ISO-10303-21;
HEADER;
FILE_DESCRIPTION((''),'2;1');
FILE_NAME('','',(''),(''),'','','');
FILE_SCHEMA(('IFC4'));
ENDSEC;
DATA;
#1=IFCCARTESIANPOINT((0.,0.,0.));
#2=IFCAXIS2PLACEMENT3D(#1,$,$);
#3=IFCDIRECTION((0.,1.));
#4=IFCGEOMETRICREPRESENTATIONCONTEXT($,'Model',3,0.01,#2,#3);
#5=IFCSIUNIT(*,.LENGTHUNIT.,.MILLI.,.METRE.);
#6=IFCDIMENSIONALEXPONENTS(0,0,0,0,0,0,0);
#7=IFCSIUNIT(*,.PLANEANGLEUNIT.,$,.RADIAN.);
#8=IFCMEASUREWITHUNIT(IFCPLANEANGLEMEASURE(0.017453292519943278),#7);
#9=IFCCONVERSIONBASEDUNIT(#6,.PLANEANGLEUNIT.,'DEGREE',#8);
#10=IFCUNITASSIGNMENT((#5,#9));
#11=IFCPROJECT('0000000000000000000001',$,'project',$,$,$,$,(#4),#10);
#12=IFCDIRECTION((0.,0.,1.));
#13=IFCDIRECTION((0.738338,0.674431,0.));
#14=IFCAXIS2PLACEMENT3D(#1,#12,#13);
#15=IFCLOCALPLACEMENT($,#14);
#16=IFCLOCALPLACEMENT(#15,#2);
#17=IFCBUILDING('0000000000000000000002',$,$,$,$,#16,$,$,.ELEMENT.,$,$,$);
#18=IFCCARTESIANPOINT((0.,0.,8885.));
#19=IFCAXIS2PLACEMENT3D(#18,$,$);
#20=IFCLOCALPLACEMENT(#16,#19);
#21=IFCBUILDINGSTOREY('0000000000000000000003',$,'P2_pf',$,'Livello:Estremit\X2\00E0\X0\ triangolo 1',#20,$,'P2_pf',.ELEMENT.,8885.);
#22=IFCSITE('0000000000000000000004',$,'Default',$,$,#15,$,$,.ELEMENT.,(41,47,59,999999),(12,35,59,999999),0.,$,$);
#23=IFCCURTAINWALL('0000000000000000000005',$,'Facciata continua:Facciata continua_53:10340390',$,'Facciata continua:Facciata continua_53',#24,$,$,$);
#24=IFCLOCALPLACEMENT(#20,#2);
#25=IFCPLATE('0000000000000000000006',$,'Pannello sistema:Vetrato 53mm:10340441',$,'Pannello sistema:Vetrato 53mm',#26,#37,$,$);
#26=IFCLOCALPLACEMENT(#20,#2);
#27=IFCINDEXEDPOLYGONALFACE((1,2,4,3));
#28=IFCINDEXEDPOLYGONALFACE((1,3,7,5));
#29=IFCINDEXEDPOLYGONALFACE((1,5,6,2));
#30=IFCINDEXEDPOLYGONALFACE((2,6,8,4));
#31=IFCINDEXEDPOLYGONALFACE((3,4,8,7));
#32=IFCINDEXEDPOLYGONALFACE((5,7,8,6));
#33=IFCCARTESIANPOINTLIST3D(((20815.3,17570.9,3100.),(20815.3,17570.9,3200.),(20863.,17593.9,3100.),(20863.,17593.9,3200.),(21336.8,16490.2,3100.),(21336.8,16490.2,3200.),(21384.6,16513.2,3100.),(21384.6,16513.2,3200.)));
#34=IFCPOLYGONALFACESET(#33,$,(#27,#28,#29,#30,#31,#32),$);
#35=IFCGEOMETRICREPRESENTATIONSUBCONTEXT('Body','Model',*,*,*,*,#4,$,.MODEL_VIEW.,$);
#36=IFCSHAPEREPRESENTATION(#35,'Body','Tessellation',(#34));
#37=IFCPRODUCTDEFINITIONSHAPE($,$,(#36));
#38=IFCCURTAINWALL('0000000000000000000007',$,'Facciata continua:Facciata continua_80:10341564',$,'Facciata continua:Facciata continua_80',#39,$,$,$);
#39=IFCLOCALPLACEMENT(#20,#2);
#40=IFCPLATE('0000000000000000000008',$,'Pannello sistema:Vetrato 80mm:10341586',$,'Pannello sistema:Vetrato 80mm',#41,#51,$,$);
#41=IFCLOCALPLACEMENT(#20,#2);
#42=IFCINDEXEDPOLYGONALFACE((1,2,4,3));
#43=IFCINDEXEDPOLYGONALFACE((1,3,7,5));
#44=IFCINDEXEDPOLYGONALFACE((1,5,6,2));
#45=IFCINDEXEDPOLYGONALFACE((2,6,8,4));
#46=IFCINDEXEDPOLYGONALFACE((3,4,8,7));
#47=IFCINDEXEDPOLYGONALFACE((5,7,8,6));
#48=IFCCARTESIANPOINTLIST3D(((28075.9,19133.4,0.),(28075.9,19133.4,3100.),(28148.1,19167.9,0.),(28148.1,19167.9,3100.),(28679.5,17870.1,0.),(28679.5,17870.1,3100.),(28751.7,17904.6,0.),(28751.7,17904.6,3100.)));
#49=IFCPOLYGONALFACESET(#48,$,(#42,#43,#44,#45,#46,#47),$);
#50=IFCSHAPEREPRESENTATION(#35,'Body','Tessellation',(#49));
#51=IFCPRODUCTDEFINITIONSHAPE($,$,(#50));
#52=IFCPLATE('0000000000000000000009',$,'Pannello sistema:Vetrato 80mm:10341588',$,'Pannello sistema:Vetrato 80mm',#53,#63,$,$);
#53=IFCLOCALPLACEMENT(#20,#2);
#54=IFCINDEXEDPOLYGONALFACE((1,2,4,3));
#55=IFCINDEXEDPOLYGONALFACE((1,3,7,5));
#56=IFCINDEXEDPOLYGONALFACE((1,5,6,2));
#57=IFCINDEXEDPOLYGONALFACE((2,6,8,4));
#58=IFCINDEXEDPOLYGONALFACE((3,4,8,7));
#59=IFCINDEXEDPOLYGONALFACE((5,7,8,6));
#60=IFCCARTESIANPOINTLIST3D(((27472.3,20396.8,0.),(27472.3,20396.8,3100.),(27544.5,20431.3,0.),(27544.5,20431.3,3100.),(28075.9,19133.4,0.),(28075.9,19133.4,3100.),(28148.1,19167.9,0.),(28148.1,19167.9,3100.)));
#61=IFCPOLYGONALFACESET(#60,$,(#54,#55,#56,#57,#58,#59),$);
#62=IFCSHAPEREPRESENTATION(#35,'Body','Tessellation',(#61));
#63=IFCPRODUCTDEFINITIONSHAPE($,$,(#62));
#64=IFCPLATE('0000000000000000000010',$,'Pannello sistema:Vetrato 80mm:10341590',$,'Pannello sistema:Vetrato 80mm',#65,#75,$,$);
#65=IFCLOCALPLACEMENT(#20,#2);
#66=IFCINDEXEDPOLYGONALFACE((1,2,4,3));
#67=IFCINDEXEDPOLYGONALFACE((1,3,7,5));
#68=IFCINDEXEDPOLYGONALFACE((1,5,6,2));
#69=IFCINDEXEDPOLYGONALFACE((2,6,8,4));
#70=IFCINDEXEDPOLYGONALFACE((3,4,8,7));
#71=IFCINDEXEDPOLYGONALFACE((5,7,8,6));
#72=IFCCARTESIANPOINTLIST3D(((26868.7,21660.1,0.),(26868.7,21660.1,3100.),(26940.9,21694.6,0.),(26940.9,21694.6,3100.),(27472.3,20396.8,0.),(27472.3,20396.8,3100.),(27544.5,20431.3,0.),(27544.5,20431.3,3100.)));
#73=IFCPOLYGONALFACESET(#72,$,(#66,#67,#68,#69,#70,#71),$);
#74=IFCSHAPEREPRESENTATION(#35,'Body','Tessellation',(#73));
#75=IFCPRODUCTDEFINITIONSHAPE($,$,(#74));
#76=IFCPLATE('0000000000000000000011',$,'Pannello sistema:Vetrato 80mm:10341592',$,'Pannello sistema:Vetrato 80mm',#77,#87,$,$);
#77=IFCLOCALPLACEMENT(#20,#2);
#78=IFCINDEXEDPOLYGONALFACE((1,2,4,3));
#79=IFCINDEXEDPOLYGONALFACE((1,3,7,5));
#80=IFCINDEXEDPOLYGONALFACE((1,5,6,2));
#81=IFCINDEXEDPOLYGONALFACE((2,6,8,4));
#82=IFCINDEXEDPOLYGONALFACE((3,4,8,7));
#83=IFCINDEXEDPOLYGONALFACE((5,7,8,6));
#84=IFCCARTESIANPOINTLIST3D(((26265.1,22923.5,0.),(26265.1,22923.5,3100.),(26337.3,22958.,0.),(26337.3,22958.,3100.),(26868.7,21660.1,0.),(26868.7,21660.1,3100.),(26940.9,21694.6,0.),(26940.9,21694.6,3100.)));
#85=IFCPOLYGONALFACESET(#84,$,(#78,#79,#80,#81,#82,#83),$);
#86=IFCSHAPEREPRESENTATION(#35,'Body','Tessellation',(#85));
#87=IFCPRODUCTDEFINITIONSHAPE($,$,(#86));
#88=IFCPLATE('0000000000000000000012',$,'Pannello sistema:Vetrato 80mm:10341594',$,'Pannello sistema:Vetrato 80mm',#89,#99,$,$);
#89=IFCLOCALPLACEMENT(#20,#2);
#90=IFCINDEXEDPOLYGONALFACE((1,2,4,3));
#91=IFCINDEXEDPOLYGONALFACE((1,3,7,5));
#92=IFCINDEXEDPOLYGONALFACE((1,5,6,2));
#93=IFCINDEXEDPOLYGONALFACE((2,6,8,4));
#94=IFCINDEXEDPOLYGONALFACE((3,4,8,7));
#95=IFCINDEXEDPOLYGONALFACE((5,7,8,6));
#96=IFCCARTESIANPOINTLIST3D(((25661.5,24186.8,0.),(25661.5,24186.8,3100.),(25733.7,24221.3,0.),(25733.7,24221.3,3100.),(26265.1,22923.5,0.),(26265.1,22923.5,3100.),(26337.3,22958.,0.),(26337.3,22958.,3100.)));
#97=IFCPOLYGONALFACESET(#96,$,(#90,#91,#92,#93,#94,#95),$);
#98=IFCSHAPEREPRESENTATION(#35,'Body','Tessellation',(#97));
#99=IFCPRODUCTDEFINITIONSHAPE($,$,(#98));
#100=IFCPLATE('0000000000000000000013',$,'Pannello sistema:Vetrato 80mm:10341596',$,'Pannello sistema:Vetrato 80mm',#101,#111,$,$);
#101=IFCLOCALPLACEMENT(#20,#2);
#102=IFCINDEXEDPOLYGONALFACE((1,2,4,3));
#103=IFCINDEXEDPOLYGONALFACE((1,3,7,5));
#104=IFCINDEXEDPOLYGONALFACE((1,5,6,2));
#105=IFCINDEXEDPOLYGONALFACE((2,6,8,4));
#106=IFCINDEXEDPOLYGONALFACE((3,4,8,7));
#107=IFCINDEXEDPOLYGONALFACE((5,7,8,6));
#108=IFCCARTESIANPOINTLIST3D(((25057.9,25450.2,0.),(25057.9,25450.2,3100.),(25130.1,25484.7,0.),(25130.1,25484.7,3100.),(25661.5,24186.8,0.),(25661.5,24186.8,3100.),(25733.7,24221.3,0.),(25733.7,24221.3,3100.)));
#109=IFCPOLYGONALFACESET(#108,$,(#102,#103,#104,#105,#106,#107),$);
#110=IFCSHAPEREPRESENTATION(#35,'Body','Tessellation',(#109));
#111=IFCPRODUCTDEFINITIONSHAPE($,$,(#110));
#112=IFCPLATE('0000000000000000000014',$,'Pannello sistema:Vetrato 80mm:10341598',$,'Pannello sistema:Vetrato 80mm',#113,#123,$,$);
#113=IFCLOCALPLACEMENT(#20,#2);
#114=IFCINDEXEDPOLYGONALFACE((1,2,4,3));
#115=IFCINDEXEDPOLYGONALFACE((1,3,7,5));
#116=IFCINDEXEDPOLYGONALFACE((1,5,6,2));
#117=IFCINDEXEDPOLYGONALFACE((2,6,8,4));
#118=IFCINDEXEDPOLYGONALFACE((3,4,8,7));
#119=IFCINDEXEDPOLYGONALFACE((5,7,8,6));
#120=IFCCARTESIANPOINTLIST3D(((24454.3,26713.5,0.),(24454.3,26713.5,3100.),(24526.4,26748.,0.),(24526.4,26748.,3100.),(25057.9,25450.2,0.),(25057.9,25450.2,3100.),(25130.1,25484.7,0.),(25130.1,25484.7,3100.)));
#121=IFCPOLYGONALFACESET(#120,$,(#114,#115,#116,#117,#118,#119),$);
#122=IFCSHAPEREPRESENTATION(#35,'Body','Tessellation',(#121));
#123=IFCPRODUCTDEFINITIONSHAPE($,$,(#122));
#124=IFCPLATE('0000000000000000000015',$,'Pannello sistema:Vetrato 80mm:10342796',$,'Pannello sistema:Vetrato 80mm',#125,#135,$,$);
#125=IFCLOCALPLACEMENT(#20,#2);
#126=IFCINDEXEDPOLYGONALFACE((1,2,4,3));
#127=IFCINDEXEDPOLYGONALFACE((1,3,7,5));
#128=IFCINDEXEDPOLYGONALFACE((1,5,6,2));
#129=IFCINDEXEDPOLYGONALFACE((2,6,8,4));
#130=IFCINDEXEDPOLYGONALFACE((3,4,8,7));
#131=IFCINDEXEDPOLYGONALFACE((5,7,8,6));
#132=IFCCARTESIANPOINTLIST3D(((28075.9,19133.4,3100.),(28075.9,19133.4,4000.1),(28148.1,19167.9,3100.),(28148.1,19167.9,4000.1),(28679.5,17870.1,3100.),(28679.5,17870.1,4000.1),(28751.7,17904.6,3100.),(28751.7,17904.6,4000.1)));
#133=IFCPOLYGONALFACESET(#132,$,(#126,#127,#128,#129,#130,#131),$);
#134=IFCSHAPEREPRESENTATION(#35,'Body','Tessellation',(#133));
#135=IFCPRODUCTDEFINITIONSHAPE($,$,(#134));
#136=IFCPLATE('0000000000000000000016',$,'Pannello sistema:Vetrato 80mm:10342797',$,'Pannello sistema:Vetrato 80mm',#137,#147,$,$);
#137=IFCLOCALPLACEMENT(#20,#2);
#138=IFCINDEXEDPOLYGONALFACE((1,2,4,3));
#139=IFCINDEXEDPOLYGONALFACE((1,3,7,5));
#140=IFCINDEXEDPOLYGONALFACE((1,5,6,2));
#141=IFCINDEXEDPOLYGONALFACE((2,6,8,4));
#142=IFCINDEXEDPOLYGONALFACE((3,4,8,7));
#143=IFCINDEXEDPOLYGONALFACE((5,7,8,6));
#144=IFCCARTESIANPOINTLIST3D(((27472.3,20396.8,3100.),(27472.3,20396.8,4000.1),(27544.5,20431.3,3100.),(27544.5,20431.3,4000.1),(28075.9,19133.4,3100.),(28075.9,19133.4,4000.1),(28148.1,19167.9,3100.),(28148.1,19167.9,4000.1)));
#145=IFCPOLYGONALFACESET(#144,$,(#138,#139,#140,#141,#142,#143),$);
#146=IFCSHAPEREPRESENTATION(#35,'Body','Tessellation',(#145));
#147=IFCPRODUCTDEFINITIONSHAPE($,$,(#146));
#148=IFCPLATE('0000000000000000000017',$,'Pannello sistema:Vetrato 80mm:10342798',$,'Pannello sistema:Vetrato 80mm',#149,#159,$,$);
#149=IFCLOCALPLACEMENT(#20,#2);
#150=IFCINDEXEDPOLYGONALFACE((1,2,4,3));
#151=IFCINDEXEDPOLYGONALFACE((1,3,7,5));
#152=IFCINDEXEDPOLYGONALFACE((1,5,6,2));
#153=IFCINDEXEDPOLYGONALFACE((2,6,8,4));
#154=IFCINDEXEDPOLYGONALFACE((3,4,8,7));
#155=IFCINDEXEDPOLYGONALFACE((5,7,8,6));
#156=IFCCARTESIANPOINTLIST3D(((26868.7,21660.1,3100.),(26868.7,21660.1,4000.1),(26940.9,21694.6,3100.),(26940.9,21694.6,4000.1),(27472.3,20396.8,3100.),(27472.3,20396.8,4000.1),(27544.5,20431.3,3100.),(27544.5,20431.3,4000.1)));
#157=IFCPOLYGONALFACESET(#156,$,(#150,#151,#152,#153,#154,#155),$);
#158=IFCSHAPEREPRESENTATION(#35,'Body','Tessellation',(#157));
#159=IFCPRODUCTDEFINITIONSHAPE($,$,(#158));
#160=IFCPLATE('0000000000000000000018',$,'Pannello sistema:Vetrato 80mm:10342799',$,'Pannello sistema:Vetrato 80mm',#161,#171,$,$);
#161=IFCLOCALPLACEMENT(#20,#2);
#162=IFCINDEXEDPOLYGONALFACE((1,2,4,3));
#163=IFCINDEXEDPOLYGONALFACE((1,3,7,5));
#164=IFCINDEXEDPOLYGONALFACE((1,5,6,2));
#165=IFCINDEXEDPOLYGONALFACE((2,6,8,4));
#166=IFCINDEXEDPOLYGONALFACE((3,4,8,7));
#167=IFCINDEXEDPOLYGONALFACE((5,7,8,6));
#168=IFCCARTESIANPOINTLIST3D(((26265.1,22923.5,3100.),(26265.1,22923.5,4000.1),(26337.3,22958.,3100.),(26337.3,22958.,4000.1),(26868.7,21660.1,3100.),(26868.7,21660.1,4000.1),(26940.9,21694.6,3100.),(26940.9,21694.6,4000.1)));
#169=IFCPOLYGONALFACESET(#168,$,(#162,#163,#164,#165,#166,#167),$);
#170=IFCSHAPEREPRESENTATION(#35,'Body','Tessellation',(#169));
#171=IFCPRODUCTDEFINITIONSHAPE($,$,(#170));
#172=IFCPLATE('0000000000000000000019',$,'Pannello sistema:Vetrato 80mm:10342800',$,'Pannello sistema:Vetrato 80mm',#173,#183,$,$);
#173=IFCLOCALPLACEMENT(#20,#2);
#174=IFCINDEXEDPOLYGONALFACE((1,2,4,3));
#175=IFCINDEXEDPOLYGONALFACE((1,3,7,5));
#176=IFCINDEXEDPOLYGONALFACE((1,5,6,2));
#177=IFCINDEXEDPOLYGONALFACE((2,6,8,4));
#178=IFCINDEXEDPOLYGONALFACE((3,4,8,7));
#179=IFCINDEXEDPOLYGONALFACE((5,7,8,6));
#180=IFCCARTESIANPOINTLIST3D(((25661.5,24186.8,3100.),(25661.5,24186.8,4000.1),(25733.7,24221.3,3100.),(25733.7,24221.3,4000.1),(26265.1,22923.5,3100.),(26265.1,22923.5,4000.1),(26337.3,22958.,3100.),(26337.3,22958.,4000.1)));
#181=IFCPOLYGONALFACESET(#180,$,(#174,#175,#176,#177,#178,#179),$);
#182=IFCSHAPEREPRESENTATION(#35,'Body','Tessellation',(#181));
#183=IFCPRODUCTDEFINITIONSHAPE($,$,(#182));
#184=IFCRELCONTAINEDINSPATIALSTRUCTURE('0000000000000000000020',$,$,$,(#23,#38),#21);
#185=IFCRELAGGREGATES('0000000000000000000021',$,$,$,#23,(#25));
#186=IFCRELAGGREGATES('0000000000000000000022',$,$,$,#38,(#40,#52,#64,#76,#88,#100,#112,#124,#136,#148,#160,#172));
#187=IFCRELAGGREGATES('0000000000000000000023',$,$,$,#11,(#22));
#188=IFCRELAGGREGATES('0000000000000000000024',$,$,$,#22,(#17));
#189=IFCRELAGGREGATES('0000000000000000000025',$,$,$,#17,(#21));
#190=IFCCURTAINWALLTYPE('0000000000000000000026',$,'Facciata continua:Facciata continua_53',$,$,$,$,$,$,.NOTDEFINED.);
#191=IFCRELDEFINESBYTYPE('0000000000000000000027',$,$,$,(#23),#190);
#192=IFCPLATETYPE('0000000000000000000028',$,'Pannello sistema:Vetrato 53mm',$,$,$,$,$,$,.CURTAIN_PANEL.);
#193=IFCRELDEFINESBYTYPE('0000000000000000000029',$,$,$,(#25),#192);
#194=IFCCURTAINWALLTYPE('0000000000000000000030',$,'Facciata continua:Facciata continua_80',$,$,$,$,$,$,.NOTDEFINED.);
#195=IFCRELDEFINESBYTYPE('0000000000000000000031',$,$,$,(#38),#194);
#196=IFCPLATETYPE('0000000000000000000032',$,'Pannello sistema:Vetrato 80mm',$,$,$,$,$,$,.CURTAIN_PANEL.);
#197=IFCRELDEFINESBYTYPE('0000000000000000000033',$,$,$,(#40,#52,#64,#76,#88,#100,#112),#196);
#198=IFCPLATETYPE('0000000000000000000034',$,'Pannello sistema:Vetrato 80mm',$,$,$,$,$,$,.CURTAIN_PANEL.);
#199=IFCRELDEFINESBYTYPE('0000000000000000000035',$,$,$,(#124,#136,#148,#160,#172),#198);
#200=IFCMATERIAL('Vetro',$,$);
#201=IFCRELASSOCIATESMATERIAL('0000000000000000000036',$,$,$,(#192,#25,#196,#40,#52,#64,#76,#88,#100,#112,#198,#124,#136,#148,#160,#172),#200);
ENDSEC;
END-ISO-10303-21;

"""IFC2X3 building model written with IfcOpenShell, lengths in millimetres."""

from ifc_helpers import new_model, entity, si_unit, converted_unit, direction, frame, frame_2d, origin, place, context, subcontext, project, spatial, rectangle, extrude, source, transform, mapped, material, type_object, type_shapes, element, aggregate, save


model = new_model("IFC2X3")

# Units and contexts
model_context = context("Model", 3, precision=0.01, world=origin(), true_north=direction((0.0, 1.0)))
body_context = subcontext(model_context, "Body", "Model", "MODEL_VIEW")
ifc_project = project(units=[si_unit("LENGTHUNIT", "METRE", prefix="MILLI"), converted_unit("PLANEANGLEUNIT", "DEGREE", entity("IfcPlaneAngleMeasure", 0.017453292519943278), si_unit("PLANEANGLEUNIT", "RADIAN"), dimensions=[0, 0, 0, 0, 0, 0, 0])], contexts=[model_context])

# Site, building, storey
site_placement = place(None, frame((0.0, 0.0, 0.0), z_axis=(0.0, 0.0, 1.0), x_axis=(0.738338, 0.674431, 0.0)))
site = spatial("IfcSite", under=ifc_project, at=site_placement, Name="Default", CompositionType="ELEMENT", RefLatitude=(41, 47, 59, 999999), RefLongitude=(12, 35, 59, 999999), RefElevation=0.0)
building_placement = place(site_placement, origin())
building = spatial("IfcBuilding", under=site, at=building_placement, CompositionType="ELEMENT")
storey_placement = place(building_placement, frame((0.0, 0.0, 8885.0)))
storey = spatial("IfcBuildingStorey", under=building, at=storey_placement, Name="P2_pf", ObjectType="Livello:Estremità triangolo 1", LongName="P2_pf", CompositionType="ELEMENT", Elevation=8885.0)

# Curtain wall, plate
curtain_wall_type_1 = type_object("IfcCurtainWallType", Name="Facciata continua:Facciata continua_53", PredefinedType="NOTDEFINED")
curtain_wall_1_placement = place(storey_placement, frame((0.0, 0.0, -8885.0)))
curtain_wall_1 = element("IfcCurtainWall", 1, at=curtain_wall_1_placement, inside=storey, type_object=curtain_wall_type_1, Name="Facciata continua:Facciata continua_53:10340390", ObjectType="Facciata continua:Facciata continua_53")
ifc_material_1 = material(Name="Vetro")
plate_type_1 = type_object("IfcPlateType", Name="Pannello sistema:Vetrato 53mm", PredefinedType="CURTAIN_PANEL", material=ifc_material_1)
shared_shape_1 = source(origin(), body_context, "Body", "SweptSolid", [
    extrude(rectangle(XDim=53.0, YDim=1200.0, at=frame_2d((0.0, 0.0), x_axis=(1.0, 0.0))), frame((0.0, -26.5, 0.0), z_axis=(0.0, 0.0, 1.0), x_axis=(0.0, 1.0, 0.0)), (0.0, 0.0, 1.0), 100.0),
])
type_shapes(plate_type_1, [shared_shape_1])
plate_1_placement = place(curtain_wall_1_placement, frame((21076.1, 17030.5, 11985.0), z_axis=(0.0, 0.0, 1.0), x_axis=(-0.434619, 0.900614, 0.0)))
plate_1 = element("IfcPlate", 2, at=plate_1_placement, type_object=plate_type_1, material=ifc_material_1, Name="Pannello sistema:Vetrato 53mm:10340441", ObjectType="Pannello sistema:Vetrato 53mm", context=body_context, shape_type="MappedRepresentation", body=[
    mapped(shared_shape_1, transform((0.0, 0.0, 0.0), scale=1.0)),
])
aggregate(curtain_wall_1, [plate_1])

# Curtain wall, plates
curtain_wall_type_2 = type_object("IfcCurtainWallType", Name="Facciata continua:Facciata continua_80", PredefinedType="NOTDEFINED")
curtain_wall_2_placement = place(storey_placement, frame((0.0, 0.0, -8885.0)))
curtain_wall_2 = element("IfcCurtainWall", 3, at=curtain_wall_2_placement, inside=storey, type_object=curtain_wall_type_2, Name="Facciata continua:Facciata continua_80:10341564", ObjectType="Facciata continua:Facciata continua_80")
plate_type_2 = type_object("IfcPlateType", Name="Pannello sistema:Vetrato 80mm", PredefinedType="CURTAIN_PANEL", material=ifc_material_1)
shared_shape_2 = source(origin(), body_context, "Body", "SweptSolid", [
    extrude(rectangle(XDim=80.0, YDim=1400.1, at=frame_2d((0.0, 0.0), x_axis=(1.0, 0.0))), frame((0.0, -40.0, 0.0), z_axis=(0.0, 0.0, 1.0), x_axis=(0.0, 1.0, 0.0)), (0.0, 0.0, 1.0), 3100.0),
])
type_shapes(plate_type_2, [shared_shape_2])
plate_2_placement = place(curtain_wall_2_placement, frame((28377.7, 18501.8, 8885.0), z_axis=(0.0, 0.0, 1.0), x_axis=(-0.431105, 0.902302, 0.0)))
plate_2 = element("IfcPlate", 4, at=plate_2_placement, type_object=plate_type_2, material=ifc_material_1, Name="Pannello sistema:Vetrato 80mm:10341586", ObjectType="Pannello sistema:Vetrato 80mm", context=body_context, shape_type="MappedRepresentation", body=[
    mapped(shared_shape_2, transform((0.0, 0.0, 0.0), scale=1.0)),
])
plate_3_placement = place(curtain_wall_2_placement, frame((27774.1, 19765.1, 8885.0), z_axis=(0.0, 0.0, 1.0), x_axis=(-0.431105, 0.902302, 0.0)))
plate_3 = element("IfcPlate", 5, at=plate_3_placement, type_object=plate_type_2, material=ifc_material_1, Name="Pannello sistema:Vetrato 80mm:10341588", ObjectType="Pannello sistema:Vetrato 80mm", context=body_context, shape_type="MappedRepresentation", body=[
    mapped(shared_shape_2, transform((0.0, 0.0, 0.0), scale=1.0)),
])
plate_4_placement = place(curtain_wall_2_placement, frame((27170.5, 21028.5, 8885.0), z_axis=(0.0, 0.0, 1.0), x_axis=(-0.431105, 0.902302, 0.0)))
plate_4 = element("IfcPlate", 6, at=plate_4_placement, type_object=plate_type_2, material=ifc_material_1, Name="Pannello sistema:Vetrato 80mm:10341590", ObjectType="Pannello sistema:Vetrato 80mm", context=body_context, shape_type="MappedRepresentation", body=[
    mapped(shared_shape_2, transform((0.0, 0.0, 0.0), scale=1.0)),
])
plate_5_placement = place(curtain_wall_2_placement, frame((26566.9, 22291.8, 8885.0), z_axis=(0.0, 0.0, 1.0), x_axis=(-0.431105, 0.902302, 0.0)))
plate_5 = element("IfcPlate", 7, at=plate_5_placement, type_object=plate_type_2, material=ifc_material_1, Name="Pannello sistema:Vetrato 80mm:10341592", ObjectType="Pannello sistema:Vetrato 80mm", context=body_context, shape_type="MappedRepresentation", body=[
    mapped(shared_shape_2, transform((0.0, 0.0, 0.0), scale=1.0)),
])
plate_6_placement = place(curtain_wall_2_placement, frame((25963.3, 23555.2, 8885.0), z_axis=(0.0, 0.0, 1.0), x_axis=(-0.431105, 0.902302, 0.0)))
plate_6 = element("IfcPlate", 8, at=plate_6_placement, type_object=plate_type_2, material=ifc_material_1, Name="Pannello sistema:Vetrato 80mm:10341594", ObjectType="Pannello sistema:Vetrato 80mm", context=body_context, shape_type="MappedRepresentation", body=[
    mapped(shared_shape_2, transform((0.0, 0.0, 0.0), scale=1.0)),
])
plate_7_placement = place(curtain_wall_2_placement, frame((25359.7, 24818.5, 8885.0), z_axis=(0.0, 0.0, 1.0), x_axis=(-0.431105, 0.902302, 0.0)))
plate_7 = element("IfcPlate", 9, at=plate_7_placement, type_object=plate_type_2, material=ifc_material_1, Name="Pannello sistema:Vetrato 80mm:10341596", ObjectType="Pannello sistema:Vetrato 80mm", context=body_context, shape_type="MappedRepresentation", body=[
    mapped(shared_shape_2, transform((0.0, 0.0, 0.0), scale=1.0)),
])
plate_8_placement = place(curtain_wall_2_placement, frame((24756.1, 26081.8, 8885.0), z_axis=(0.0, 0.0, 1.0), x_axis=(-0.431105, 0.902302, 0.0)))
plate_8 = element("IfcPlate", 10, at=plate_8_placement, type_object=plate_type_2, material=ifc_material_1, Name="Pannello sistema:Vetrato 80mm:10341598", ObjectType="Pannello sistema:Vetrato 80mm", context=body_context, shape_type="MappedRepresentation", body=[
    mapped(shared_shape_2, transform((0.0, 0.0, 0.0), scale=1.0)),
])
plate_type_3 = type_object("IfcPlateType", Name="Pannello sistema:Vetrato 80mm", PredefinedType="CURTAIN_PANEL", material=ifc_material_1)
shared_shape_3 = source(origin(), body_context, "Body", "SweptSolid", [
    extrude(rectangle(XDim=80.0, YDim=1400.1, at=frame_2d((0.0, 0.0), x_axis=(1.0, 0.0))), frame((0.0, -40.0, 0.0), z_axis=(0.0, 0.0, 1.0), x_axis=(0.0, 1.0, 0.0)), (0.0, 0.0, 1.0), 900.1),
])
type_shapes(plate_type_3, [shared_shape_3])
plate_9_placement = place(curtain_wall_2_placement, frame((28377.7, 18501.8, 11985.0), z_axis=(0.0, 0.0, 1.0), x_axis=(-0.431105, 0.902302, 0.0)))
plate_9 = element("IfcPlate", 11, at=plate_9_placement, type_object=plate_type_3, material=ifc_material_1, Name="Pannello sistema:Vetrato 80mm:10342796", ObjectType="Pannello sistema:Vetrato 80mm", context=body_context, shape_type="MappedRepresentation", body=[
    mapped(shared_shape_3, transform((0.0, 0.0, 0.0), scale=1.0)),
])
plate_10_placement = place(curtain_wall_2_placement, frame((27774.1, 19765.1, 11985.0), z_axis=(0.0, 0.0, 1.0), x_axis=(-0.431105, 0.902302, 0.0)))
plate_10 = element("IfcPlate", 12, at=plate_10_placement, type_object=plate_type_3, material=ifc_material_1, Name="Pannello sistema:Vetrato 80mm:10342797", ObjectType="Pannello sistema:Vetrato 80mm", context=body_context, shape_type="MappedRepresentation", body=[
    mapped(shared_shape_3, transform((0.0, 0.0, 0.0), scale=1.0)),
])
plate_11_placement = place(curtain_wall_2_placement, frame((27170.5, 21028.5, 11985.0), z_axis=(0.0, 0.0, 1.0), x_axis=(-0.431105, 0.902302, 0.0)))
plate_11 = element("IfcPlate", 13, at=plate_11_placement, type_object=plate_type_3, material=ifc_material_1, Name="Pannello sistema:Vetrato 80mm:10342798", ObjectType="Pannello sistema:Vetrato 80mm", context=body_context, shape_type="MappedRepresentation", body=[
    mapped(shared_shape_3, transform((0.0, 0.0, 0.0), scale=1.0)),
])
plate_12_placement = place(curtain_wall_2_placement, frame((26566.9, 22291.8, 11985.0), z_axis=(0.0, 0.0, 1.0), x_axis=(-0.431105, 0.902302, 0.0)))
plate_12 = element("IfcPlate", 14, at=plate_12_placement, type_object=plate_type_3, material=ifc_material_1, Name="Pannello sistema:Vetrato 80mm:10342799", ObjectType="Pannello sistema:Vetrato 80mm", context=body_context, shape_type="MappedRepresentation", body=[
    mapped(shared_shape_3, transform((0.0, 0.0, 0.0), scale=1.0)),
])
plate_13_placement = place(curtain_wall_2_placement, frame((25963.3, 23555.2, 11985.0), z_axis=(0.0, 0.0, 1.0), x_axis=(-0.431105, 0.902302, 0.0)))
plate_13 = element("IfcPlate", 15, at=plate_13_placement, type_object=plate_type_3, material=ifc_material_1, Name="Pannello sistema:Vetrato 80mm:10342800", ObjectType="Pannello sistema:Vetrato 80mm", context=body_context, shape_type="MappedRepresentation", body=[
    mapped(shared_shape_3, transform((0.0, 0.0, 0.0), scale=1.0)),
])
aggregate(curtain_wall_2, [plate_2, plate_3, plate_4, plate_5, plate_6, plate_7, plate_8, plate_9, plate_10, plate_11, plate_12, plate_13])

save(model, "model.ifc")
